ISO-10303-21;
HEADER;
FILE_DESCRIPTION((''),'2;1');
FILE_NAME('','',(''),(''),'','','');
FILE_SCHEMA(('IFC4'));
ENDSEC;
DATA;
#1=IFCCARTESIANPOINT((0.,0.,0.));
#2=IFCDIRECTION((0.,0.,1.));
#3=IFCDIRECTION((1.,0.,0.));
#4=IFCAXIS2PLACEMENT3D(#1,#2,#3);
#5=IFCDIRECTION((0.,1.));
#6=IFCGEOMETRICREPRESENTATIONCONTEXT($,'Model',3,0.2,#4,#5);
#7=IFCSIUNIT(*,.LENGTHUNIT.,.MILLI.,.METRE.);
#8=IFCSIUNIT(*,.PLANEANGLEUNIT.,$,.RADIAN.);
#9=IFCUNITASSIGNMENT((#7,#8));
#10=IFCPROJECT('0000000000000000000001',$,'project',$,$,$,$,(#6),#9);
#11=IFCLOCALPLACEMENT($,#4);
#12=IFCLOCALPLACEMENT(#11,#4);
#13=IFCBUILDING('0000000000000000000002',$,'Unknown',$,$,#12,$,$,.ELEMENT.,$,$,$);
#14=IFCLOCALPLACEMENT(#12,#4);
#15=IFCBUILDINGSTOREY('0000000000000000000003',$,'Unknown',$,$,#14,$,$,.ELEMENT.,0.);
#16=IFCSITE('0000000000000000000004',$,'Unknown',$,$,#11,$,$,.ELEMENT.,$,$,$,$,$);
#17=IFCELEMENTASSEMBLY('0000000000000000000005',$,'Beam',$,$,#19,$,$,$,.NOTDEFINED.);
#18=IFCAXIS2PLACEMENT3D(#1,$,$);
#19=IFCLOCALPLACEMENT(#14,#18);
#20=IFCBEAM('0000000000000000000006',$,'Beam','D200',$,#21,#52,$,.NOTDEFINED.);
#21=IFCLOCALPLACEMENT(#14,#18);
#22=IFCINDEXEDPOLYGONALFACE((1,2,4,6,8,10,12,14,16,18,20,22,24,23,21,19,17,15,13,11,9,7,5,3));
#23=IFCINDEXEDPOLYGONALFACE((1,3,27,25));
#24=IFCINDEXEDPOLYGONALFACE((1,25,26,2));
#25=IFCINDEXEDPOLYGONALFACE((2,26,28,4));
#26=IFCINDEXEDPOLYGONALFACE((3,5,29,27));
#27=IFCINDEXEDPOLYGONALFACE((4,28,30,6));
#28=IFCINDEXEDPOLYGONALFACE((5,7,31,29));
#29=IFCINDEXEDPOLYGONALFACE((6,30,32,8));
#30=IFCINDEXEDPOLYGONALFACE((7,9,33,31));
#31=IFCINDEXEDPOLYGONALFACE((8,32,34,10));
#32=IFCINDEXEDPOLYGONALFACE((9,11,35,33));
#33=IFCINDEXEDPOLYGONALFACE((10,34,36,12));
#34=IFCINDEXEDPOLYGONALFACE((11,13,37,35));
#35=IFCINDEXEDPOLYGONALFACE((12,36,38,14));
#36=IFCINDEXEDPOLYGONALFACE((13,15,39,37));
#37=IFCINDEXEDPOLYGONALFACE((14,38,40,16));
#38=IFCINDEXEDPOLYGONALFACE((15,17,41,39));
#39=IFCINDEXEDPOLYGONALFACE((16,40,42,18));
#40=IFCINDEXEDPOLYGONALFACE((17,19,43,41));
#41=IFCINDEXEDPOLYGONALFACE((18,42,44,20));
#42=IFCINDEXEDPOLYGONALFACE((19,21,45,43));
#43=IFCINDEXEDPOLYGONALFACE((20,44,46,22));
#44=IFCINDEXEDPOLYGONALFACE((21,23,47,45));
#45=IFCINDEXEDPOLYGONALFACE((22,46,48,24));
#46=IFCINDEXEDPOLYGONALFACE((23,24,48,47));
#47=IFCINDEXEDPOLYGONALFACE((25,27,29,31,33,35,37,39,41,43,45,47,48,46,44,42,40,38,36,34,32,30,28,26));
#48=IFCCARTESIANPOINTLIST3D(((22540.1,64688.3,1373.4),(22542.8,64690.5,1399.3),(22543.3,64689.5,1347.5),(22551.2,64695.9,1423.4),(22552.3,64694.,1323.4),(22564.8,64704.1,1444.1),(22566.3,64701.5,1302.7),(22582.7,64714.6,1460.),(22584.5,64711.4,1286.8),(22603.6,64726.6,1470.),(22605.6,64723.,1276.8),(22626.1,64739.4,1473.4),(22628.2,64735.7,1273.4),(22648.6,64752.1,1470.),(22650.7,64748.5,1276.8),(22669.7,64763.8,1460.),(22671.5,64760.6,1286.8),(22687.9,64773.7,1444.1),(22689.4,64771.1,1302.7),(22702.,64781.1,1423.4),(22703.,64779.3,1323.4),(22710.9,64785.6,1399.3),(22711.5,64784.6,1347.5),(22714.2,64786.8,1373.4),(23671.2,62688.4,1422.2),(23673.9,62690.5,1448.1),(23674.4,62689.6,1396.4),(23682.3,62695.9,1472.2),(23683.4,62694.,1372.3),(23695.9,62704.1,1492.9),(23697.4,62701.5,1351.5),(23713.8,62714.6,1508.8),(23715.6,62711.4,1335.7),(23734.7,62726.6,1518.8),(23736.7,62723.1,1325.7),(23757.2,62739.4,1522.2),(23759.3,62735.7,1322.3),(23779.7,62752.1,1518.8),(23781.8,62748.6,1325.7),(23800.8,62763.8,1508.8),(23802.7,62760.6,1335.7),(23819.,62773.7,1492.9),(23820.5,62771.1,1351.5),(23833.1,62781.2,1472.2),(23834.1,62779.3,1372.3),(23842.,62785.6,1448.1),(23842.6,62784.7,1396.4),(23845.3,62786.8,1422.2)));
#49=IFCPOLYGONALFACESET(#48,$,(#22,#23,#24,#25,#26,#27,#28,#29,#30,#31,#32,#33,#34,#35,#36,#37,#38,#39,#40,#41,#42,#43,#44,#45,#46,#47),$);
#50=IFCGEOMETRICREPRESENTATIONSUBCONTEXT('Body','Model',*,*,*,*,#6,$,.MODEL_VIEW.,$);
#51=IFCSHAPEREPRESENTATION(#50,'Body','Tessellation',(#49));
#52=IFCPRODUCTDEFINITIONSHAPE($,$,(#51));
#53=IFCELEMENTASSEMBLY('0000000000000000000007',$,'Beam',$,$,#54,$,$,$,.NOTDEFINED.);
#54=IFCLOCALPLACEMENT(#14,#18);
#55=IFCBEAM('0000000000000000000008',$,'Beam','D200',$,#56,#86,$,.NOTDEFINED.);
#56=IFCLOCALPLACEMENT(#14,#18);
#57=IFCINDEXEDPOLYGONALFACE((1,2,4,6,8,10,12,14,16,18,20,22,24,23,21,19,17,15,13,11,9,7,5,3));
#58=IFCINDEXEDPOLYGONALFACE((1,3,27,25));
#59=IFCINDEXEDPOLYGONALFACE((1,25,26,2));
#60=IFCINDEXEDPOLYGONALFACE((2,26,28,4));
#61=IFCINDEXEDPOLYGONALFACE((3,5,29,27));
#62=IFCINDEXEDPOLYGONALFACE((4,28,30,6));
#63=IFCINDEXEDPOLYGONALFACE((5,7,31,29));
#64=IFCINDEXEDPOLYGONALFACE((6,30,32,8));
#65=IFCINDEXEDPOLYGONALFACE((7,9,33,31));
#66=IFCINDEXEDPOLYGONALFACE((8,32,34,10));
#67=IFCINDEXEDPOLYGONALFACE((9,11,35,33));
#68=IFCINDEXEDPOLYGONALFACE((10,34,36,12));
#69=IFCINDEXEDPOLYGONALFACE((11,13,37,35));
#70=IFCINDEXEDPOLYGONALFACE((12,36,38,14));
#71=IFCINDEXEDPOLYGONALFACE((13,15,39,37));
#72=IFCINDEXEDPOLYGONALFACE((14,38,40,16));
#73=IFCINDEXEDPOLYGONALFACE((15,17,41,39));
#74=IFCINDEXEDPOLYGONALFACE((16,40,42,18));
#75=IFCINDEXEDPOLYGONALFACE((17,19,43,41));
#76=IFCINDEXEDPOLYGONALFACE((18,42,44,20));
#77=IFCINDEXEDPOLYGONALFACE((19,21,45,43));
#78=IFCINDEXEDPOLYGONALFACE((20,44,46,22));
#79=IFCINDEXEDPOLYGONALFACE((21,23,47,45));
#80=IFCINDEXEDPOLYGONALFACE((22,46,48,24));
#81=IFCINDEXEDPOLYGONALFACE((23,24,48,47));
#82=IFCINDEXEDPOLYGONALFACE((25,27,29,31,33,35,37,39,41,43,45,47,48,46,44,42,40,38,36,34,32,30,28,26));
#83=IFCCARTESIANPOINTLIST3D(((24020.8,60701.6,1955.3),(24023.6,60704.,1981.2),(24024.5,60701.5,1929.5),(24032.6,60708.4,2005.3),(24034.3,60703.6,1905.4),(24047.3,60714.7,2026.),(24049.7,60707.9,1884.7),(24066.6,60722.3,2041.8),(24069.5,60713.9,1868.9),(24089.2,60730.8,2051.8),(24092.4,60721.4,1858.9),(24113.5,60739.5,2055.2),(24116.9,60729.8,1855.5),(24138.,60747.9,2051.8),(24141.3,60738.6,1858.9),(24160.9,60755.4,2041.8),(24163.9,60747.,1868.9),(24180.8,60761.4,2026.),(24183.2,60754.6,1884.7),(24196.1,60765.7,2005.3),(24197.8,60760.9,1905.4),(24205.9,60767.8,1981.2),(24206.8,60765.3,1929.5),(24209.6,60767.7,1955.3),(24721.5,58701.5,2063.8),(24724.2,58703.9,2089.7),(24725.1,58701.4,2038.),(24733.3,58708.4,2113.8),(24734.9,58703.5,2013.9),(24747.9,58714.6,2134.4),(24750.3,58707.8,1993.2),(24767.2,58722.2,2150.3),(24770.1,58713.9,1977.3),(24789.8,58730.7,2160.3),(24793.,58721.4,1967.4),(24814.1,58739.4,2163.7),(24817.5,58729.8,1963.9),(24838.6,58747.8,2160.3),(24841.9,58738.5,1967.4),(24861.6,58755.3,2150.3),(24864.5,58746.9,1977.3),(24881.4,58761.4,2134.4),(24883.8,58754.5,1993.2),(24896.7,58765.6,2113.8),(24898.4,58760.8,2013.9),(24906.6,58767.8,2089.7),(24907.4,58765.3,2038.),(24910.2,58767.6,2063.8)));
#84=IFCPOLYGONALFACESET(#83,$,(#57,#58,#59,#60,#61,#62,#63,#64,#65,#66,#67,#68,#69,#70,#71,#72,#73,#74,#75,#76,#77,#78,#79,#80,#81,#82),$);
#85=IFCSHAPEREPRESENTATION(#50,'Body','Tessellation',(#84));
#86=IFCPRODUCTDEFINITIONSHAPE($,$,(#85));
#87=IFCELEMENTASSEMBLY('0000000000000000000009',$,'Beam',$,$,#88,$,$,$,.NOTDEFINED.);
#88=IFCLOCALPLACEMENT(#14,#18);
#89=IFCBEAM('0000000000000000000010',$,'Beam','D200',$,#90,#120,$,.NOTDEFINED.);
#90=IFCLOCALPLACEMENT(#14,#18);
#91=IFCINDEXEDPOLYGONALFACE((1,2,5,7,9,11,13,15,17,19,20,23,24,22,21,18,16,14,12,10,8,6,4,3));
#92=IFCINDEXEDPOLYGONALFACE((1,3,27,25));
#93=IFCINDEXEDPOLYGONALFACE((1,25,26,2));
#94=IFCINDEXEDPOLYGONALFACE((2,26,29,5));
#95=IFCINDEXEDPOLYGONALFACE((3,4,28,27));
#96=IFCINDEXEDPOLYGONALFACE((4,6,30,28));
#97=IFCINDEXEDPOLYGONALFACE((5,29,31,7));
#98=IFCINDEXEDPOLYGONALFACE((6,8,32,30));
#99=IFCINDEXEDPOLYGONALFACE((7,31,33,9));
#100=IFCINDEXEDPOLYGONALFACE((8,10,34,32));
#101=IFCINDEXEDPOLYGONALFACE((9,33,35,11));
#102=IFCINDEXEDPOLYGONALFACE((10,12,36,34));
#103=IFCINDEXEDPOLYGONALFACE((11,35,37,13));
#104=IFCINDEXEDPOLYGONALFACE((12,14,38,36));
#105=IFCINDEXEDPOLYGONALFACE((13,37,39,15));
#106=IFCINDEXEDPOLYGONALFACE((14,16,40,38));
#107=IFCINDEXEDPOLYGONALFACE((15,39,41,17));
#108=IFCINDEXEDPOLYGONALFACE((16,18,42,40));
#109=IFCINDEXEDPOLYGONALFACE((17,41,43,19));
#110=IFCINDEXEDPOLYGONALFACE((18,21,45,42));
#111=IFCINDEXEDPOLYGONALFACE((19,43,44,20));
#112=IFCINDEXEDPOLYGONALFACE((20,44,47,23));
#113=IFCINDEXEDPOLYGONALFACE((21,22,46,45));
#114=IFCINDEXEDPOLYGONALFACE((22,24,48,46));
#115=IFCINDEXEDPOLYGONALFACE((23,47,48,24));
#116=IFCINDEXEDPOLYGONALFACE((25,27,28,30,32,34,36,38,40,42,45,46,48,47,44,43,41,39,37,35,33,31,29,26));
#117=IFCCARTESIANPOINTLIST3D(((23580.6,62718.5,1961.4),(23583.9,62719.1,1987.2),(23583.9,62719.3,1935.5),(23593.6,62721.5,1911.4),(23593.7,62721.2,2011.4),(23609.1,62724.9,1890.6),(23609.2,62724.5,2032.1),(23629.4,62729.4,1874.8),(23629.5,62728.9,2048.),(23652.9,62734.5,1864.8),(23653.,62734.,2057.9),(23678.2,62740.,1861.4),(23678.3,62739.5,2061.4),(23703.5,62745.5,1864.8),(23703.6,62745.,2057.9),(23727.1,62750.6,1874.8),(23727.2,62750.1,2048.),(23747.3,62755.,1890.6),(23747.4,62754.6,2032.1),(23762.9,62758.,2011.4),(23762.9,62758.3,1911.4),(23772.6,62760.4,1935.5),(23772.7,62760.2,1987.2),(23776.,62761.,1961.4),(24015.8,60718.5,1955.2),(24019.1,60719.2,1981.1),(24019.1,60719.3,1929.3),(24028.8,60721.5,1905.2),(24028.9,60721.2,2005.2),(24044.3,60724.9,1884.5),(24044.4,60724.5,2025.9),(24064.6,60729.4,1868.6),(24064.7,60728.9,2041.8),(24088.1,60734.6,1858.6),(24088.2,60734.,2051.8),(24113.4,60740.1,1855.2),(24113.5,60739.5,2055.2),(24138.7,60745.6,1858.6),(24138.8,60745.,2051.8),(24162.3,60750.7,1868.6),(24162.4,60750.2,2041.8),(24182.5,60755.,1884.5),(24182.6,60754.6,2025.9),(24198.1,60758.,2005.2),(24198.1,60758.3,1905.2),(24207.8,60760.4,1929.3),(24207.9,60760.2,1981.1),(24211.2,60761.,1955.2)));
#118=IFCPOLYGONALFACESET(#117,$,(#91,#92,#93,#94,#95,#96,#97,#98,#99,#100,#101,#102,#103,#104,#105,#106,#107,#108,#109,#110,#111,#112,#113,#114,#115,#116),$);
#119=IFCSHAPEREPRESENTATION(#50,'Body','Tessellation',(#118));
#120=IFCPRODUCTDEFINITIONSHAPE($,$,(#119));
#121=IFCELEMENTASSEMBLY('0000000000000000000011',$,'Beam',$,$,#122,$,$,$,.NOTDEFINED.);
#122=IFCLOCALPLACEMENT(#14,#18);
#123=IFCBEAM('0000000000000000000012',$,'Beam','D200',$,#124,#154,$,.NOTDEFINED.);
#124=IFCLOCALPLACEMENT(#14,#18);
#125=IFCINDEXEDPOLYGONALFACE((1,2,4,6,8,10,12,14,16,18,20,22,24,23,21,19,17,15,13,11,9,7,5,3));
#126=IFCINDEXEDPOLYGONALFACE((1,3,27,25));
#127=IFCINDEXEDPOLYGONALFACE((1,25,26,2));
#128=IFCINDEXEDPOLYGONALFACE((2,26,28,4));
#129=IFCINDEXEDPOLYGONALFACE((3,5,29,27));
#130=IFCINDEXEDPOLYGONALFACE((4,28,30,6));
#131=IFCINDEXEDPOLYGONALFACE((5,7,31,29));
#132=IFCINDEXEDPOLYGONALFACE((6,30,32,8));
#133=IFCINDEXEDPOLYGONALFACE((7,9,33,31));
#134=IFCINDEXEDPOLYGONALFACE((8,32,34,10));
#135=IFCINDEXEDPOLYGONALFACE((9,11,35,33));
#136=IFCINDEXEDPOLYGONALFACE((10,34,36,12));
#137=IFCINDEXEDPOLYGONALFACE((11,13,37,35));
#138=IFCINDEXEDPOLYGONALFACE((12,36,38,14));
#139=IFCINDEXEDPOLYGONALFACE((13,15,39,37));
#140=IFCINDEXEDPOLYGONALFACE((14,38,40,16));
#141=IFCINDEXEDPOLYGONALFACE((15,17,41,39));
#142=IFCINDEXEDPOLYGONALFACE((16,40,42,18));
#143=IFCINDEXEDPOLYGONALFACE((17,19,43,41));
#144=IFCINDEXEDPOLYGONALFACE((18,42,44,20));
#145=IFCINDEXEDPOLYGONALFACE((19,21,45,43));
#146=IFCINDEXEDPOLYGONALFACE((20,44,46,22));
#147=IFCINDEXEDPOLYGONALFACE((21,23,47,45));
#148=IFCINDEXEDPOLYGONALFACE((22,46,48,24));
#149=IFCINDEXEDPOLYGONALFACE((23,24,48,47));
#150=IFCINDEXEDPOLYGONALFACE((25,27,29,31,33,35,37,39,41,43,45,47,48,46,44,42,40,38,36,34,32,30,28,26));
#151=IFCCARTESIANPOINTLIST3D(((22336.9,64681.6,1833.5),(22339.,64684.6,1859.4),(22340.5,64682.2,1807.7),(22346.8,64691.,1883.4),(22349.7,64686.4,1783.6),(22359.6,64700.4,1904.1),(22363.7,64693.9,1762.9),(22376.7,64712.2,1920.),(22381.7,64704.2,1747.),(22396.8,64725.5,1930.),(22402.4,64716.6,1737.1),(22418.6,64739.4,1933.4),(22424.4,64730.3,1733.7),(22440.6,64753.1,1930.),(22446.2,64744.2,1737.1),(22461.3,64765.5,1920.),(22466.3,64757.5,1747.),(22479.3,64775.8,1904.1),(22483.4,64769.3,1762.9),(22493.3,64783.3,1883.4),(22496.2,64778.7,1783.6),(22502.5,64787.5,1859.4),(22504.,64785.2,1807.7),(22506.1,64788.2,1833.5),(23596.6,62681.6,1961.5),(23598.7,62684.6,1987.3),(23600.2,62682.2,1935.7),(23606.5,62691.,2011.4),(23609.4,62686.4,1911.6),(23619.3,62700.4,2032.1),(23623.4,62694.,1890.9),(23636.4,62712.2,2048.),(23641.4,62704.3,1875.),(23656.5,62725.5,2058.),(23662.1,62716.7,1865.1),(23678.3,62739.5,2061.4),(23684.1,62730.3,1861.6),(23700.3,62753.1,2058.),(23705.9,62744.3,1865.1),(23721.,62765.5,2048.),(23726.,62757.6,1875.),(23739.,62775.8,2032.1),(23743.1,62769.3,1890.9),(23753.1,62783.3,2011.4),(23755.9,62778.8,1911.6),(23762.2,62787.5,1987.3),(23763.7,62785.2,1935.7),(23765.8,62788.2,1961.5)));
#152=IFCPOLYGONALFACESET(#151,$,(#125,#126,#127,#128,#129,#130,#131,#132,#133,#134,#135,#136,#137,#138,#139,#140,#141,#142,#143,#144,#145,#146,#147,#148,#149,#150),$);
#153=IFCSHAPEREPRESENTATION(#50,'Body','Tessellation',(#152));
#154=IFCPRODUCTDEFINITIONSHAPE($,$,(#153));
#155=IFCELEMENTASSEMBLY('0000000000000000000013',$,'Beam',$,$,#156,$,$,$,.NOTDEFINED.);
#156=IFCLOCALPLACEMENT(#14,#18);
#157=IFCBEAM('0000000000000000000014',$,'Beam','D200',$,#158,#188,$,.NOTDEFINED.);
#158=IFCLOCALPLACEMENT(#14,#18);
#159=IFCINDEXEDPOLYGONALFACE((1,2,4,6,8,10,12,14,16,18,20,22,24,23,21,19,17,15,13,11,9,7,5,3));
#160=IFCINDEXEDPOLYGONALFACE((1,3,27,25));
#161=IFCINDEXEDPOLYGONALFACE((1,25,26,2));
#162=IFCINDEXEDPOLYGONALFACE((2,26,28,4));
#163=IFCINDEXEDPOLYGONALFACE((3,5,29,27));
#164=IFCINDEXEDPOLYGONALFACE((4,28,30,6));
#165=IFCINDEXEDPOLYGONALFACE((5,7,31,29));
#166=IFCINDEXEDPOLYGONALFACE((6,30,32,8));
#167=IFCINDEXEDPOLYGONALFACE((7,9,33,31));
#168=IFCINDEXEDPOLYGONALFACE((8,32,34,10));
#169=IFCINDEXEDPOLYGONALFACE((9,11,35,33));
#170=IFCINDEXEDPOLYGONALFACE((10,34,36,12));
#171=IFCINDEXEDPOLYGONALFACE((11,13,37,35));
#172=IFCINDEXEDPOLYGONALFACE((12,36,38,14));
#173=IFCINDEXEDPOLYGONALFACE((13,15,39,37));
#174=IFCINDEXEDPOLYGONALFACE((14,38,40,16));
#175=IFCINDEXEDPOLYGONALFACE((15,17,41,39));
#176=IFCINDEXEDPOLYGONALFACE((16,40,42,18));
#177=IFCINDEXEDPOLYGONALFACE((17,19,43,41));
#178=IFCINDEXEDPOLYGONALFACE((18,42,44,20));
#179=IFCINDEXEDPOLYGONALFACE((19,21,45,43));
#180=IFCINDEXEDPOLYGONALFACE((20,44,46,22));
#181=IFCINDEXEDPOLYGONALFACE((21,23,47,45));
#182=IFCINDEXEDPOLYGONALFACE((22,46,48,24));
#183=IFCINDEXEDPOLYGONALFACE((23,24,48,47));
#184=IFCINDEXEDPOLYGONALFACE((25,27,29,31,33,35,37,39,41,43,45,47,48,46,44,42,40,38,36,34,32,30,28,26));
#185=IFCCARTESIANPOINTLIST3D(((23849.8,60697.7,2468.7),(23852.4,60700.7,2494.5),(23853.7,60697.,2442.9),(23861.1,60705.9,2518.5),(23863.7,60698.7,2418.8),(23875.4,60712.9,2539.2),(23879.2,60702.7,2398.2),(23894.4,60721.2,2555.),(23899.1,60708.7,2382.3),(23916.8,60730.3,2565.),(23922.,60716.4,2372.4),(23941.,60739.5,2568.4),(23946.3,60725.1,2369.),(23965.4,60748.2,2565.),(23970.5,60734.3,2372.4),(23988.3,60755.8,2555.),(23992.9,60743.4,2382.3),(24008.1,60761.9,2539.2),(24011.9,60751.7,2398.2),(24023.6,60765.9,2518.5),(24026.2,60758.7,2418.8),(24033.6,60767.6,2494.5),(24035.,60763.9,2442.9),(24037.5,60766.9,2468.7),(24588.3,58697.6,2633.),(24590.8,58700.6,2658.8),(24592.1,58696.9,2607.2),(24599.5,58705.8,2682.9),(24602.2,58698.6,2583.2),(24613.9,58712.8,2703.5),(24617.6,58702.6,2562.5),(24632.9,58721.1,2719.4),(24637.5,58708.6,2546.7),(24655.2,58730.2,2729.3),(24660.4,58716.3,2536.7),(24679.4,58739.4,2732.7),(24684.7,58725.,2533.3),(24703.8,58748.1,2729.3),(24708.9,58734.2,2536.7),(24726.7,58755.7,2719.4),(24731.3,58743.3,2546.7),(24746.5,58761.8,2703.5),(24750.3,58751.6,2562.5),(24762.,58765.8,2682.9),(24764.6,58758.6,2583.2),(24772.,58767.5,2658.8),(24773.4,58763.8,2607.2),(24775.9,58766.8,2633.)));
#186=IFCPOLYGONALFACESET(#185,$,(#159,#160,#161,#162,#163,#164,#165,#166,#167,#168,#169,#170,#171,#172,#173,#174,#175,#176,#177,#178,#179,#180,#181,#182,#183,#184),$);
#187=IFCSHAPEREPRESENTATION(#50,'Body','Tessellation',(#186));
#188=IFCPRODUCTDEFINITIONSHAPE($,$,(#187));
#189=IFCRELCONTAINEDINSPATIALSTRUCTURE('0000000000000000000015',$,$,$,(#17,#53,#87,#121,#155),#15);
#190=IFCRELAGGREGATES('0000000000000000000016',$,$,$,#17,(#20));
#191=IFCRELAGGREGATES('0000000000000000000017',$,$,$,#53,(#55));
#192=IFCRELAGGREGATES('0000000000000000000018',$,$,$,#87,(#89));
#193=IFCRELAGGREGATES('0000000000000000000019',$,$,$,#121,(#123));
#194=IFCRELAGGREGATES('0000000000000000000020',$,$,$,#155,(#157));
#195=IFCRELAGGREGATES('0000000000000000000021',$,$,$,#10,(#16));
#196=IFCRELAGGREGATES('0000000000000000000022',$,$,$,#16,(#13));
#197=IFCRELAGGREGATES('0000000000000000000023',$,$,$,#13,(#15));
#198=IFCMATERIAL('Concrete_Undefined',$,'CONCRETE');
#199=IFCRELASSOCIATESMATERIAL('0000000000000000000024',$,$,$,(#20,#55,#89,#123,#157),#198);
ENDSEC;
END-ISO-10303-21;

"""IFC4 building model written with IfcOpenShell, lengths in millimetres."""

from ifc_helpers import new_model, si_unit, direction, frame, origin_with_axes, place, context, subcontext, project, spatial, line, indexed_curve, outline, extrude, material, element, aggregate, save


model = new_model("IFC4")

# Units and contexts
model_context = context("Model", 3, precision=0.2, world=origin_with_axes(), true_north=direction((0.0, 1.0)))
body_context = subcontext(model_context, "Body", "Model", "MODEL_VIEW")
ifc_project = project(units=[si_unit("LENGTHUNIT", "METRE", prefix="MILLI"), si_unit("PLANEANGLEUNIT", "RADIAN")], contexts=[model_context])

# Site, building, storey
site_placement = place(None, origin_with_axes())
site = spatial("IfcSite", under=ifc_project, at=site_placement, Name="Unknown", CompositionType="ELEMENT")
building_placement = place(site_placement, origin_with_axes())
building = spatial("IfcBuilding", under=site, at=building_placement, Name="Unknown", CompositionType="ELEMENT")
storey_placement = place(building_placement, origin_with_axes())
storey = spatial("IfcBuildingStorey", under=building, at=storey_placement, Name="Unknown", CompositionType="ELEMENT", Elevation=0.0)

# Element assemblies, beams
ifc_material = material(Name="Concrete_Undefined", Category="CONCRETE")
assembly_1_placement = place(storey_placement, frame((22627.1, 64737.6, 1373.4), z_axis=(-0.870434, -0.492284, 0.0), x_axis=(0.492173, -0.870238, 0.021244)))
assembly_1 = element("IfcElementAssembly", 1, at=assembly_1_placement, inside=storey, Name="Beam", PredefinedType="NOTDEFINED")
beam_1_placement = place(assembly_1_placement, origin_with_axes())
beam_1 = element("IfcBeam", 2, at=beam_1_placement, material=ifc_material, Name="Beam", Description="D200", PredefinedType="NOTDEFINED", context=body_context, shape_type="SolidModel", body=[
    extrude(outline(indexed_curve([(100.0, 0.0), (96.6, 25.9), (86.6, 50.0), (70.7, 70.7), (50.0, 86.6), (25.9, 96.6), (0.0, 100.0), (-25.9, 96.6), (-50.0, 86.6), (-70.7, 70.7), (-86.6, 50.0), (-96.6, 25.9), (-100.0, 0.0), (-96.6, -25.9), (-86.6, -50.0), (-70.7, -70.7), (-50.0, -86.6), (-25.9, -96.6), (0.0, -100.0), (25.9, -96.6), (50.0, -86.6), (70.7, -70.7), (86.6, -50.0), (96.6, -25.9)], segments=[line(1, 2, 3, 4, 5, 6, 7, 8, 9, 10, 11, 12, 13, 14, 15, 16, 17, 18, 19, 20, 21, 22, 23, 24, 1)])), frame((0.0, 0.0, 0.0), z_axis=(-1.0, 0.0, 0.0), x_axis=(0.0, 0.0, 1.0)), (0.0, 0.0, -1.0), 2298.2),
])
aggregate(assembly_1, [beam_1])
assembly_2_placement = place(storey_placement, frame((24115.2, 60734.7, 1955.3), z_axis=(-0.943772, -0.330596, 0.0), x_axis=(0.330164, -0.942538, 0.051117)))
assembly_2 = element("IfcElementAssembly", 3, at=assembly_2_placement, inside=storey, Name="Beam", PredefinedType="NOTDEFINED")
beam_2_placement = place(assembly_2_placement, origin_with_axes())
beam_2 = element("IfcBeam", 4, at=beam_2_placement, material=ifc_material, Name="Beam", Description="D200", PredefinedType="NOTDEFINED", context=body_context, shape_type="SolidModel", body=[
    extrude(outline(indexed_curve([(100.0, 0.0), (96.6, 25.9), (86.6, 50.0), (70.7, 70.7), (50.0, 86.6), (25.9, 96.6), (0.0, 100.0), (-25.9, 96.6), (-50.0, 86.6), (-70.7, 70.7), (-86.6, 50.0), (-96.6, 25.9), (-100.0, 0.0), (-96.6, -25.9), (-86.6, -50.0), (-70.7, -70.7), (-50.0, -86.6), (-25.9, -96.6), (0.0, -100.0), (25.9, -96.6), (50.0, -86.6), (70.7, -70.7), (86.6, -50.0), (96.6, -25.9)], segments=[line(1, 2, 3, 4, 5, 6, 7, 8, 9, 10, 11, 12, 13, 14, 15, 16, 17, 18, 19, 20, 21, 22, 23, 24, 1)])), frame((0.0, 0.0, 0.0), z_axis=(-1.0, 0.0, 0.0), x_axis=(0.0, 0.0, 1.0)), (0.0, 0.0, -1.0), 2122.0),
])
aggregate(assembly_2, [beam_2])
assembly_3_placement = place(storey_placement, frame((23678.3, 62739.8, 1961.4), z_axis=(-0.977134, -0.212626, 0.0), x_axis=(0.212625, -0.977129, -0.003001)))
assembly_3 = element("IfcElementAssembly", 5, at=assembly_3_placement, inside=storey, Name="Beam", PredefinedType="NOTDEFINED")
beam_3_placement = place(assembly_3_placement, origin_with_axes())
beam_3 = element("IfcBeam", 6, at=beam_3_placement, material=ifc_material, Name="Beam", Description="D200", PredefinedType="NOTDEFINED", context=body_context, shape_type="SolidModel", body=[
    extrude(outline(indexed_curve([(100.0, 0.0), (96.6, 25.9), (86.6, 50.0), (70.7, 70.7), (50.0, 86.6), (25.9, 96.6), (0.0, 100.0), (-25.9, 96.6), (-50.0, 86.6), (-70.7, 70.7), (-86.6, 50.0), (-96.6, 25.9), (-100.0, 0.0), (-96.6, -25.9), (-86.6, -50.0), (-70.7, -70.7), (-50.0, -86.6), (-25.9, -96.6), (0.0, -100.0), (25.9, -96.6), (50.0, -86.6), (70.7, -70.7), (86.6, -50.0), (96.6, -25.9)], segments=[line(1, 2, 3, 4, 5, 6, 7, 8, 9, 10, 11, 12, 13, 14, 15, 16, 17, 18, 19, 20, 21, 22, 23, 24, 1)])), frame((0.0, 0.0, 0.0), z_axis=(-1.0, 0.0, 0.0), x_axis=(0.0, 0.0, 1.0)), (0.0, 0.0, -1.0), 2046.8),
])
aggregate(assembly_3, [beam_3])
assembly_4_placement = place(storey_placement, frame((22421.5, 64734.9, 1833.5), z_axis=(-0.846144, -0.532955, 0.0), x_axis=(0.532175, -0.844906, 0.054066)))
assembly_4 = element("IfcElementAssembly", 7, at=assembly_4_placement, inside=storey, Name="Beam", PredefinedType="NOTDEFINED")
beam_4_placement = place(assembly_4_placement, origin_with_axes())
beam_4 = element("IfcBeam", 8, at=beam_4_placement, material=ifc_material, Name="Beam", Description="D200", PredefinedType="NOTDEFINED", context=body_context, shape_type="SolidModel", body=[
    extrude(outline(indexed_curve([(100.0, 0.0), (96.6, 25.9), (86.6, 50.0), (70.7, 70.7), (50.0, 86.6), (25.9, 96.6), (0.0, 100.0), (-25.9, 96.6), (-50.0, 86.6), (-70.7, 70.7), (-86.6, 50.0), (-96.6, 25.9), (-100.0, 0.0), (-96.6, -25.9), (-86.6, -50.0), (-70.7, -70.7), (-50.0, -86.6), (-25.9, -96.6), (0.0, -100.0), (25.9, -96.6), (50.0, -86.6), (70.7, -70.7), (86.6, -50.0), (96.6, -25.9)], segments=[line(1, 2, 3, 4, 5, 6, 7, 8, 9, 10, 11, 12, 13, 14, 15, 16, 17, 18, 19, 20, 21, 22, 23, 24, 1)])), frame((0.0, 0.0, 0.0), z_axis=(-1.0, 0.0, 0.0), x_axis=(0.0, 0.0, 1.0)), (0.0, 0.0, -1.0), 2367.1),
])
aggregate(assembly_4, [beam_4])
assembly_5_placement = place(storey_placement, frame((23943.7, 60732.3, 2468.7), z_axis=(-0.93811, -0.346337, 0.0), x_axis=(0.345313, -0.935335, 0.076863)))
assembly_5 = element("IfcElementAssembly", 9, at=assembly_5_placement, inside=storey, Name="Beam", PredefinedType="NOTDEFINED")
beam_5_placement = place(assembly_5_placement, origin_with_axes())
beam_5 = element("IfcBeam", 10, at=beam_5_placement, material=ifc_material, Name="Beam", Description="D200", PredefinedType="NOTDEFINED", context=body_context, shape_type="SolidModel", body=[
    extrude(outline(indexed_curve([(100.0, 0.0), (96.6, 25.9), (86.6, 50.0), (70.7, 70.7), (50.0, 86.6), (25.9, 96.6), (0.0, 100.0), (-25.9, 96.6), (-50.0, 86.6), (-70.7, 70.7), (-86.6, 50.0), (-96.6, 25.9), (-100.0, 0.0), (-96.6, -25.9), (-86.6, -50.0), (-70.7, -70.7), (-50.0, -86.6), (-25.9, -96.6), (0.0, -100.0), (25.9, -96.6), (50.0, -86.6), (70.7, -70.7), (86.6, -50.0), (96.6, -25.9)], segments=[line(1, 2, 3, 4, 5, 6, 7, 8, 9, 10, 11, 12, 13, 14, 15, 16, 17, 18, 19, 20, 21, 22, 23, 24, 1)])), frame((0.0, 0.0, 0.0), z_axis=(-1.0, 0.0, 0.0), x_axis=(0.0, 0.0, 1.0)), (0.0, 0.0, -1.0), 2138.4),
])
aggregate(assembly_5, [beam_5])

save(model, "model.ifc")
